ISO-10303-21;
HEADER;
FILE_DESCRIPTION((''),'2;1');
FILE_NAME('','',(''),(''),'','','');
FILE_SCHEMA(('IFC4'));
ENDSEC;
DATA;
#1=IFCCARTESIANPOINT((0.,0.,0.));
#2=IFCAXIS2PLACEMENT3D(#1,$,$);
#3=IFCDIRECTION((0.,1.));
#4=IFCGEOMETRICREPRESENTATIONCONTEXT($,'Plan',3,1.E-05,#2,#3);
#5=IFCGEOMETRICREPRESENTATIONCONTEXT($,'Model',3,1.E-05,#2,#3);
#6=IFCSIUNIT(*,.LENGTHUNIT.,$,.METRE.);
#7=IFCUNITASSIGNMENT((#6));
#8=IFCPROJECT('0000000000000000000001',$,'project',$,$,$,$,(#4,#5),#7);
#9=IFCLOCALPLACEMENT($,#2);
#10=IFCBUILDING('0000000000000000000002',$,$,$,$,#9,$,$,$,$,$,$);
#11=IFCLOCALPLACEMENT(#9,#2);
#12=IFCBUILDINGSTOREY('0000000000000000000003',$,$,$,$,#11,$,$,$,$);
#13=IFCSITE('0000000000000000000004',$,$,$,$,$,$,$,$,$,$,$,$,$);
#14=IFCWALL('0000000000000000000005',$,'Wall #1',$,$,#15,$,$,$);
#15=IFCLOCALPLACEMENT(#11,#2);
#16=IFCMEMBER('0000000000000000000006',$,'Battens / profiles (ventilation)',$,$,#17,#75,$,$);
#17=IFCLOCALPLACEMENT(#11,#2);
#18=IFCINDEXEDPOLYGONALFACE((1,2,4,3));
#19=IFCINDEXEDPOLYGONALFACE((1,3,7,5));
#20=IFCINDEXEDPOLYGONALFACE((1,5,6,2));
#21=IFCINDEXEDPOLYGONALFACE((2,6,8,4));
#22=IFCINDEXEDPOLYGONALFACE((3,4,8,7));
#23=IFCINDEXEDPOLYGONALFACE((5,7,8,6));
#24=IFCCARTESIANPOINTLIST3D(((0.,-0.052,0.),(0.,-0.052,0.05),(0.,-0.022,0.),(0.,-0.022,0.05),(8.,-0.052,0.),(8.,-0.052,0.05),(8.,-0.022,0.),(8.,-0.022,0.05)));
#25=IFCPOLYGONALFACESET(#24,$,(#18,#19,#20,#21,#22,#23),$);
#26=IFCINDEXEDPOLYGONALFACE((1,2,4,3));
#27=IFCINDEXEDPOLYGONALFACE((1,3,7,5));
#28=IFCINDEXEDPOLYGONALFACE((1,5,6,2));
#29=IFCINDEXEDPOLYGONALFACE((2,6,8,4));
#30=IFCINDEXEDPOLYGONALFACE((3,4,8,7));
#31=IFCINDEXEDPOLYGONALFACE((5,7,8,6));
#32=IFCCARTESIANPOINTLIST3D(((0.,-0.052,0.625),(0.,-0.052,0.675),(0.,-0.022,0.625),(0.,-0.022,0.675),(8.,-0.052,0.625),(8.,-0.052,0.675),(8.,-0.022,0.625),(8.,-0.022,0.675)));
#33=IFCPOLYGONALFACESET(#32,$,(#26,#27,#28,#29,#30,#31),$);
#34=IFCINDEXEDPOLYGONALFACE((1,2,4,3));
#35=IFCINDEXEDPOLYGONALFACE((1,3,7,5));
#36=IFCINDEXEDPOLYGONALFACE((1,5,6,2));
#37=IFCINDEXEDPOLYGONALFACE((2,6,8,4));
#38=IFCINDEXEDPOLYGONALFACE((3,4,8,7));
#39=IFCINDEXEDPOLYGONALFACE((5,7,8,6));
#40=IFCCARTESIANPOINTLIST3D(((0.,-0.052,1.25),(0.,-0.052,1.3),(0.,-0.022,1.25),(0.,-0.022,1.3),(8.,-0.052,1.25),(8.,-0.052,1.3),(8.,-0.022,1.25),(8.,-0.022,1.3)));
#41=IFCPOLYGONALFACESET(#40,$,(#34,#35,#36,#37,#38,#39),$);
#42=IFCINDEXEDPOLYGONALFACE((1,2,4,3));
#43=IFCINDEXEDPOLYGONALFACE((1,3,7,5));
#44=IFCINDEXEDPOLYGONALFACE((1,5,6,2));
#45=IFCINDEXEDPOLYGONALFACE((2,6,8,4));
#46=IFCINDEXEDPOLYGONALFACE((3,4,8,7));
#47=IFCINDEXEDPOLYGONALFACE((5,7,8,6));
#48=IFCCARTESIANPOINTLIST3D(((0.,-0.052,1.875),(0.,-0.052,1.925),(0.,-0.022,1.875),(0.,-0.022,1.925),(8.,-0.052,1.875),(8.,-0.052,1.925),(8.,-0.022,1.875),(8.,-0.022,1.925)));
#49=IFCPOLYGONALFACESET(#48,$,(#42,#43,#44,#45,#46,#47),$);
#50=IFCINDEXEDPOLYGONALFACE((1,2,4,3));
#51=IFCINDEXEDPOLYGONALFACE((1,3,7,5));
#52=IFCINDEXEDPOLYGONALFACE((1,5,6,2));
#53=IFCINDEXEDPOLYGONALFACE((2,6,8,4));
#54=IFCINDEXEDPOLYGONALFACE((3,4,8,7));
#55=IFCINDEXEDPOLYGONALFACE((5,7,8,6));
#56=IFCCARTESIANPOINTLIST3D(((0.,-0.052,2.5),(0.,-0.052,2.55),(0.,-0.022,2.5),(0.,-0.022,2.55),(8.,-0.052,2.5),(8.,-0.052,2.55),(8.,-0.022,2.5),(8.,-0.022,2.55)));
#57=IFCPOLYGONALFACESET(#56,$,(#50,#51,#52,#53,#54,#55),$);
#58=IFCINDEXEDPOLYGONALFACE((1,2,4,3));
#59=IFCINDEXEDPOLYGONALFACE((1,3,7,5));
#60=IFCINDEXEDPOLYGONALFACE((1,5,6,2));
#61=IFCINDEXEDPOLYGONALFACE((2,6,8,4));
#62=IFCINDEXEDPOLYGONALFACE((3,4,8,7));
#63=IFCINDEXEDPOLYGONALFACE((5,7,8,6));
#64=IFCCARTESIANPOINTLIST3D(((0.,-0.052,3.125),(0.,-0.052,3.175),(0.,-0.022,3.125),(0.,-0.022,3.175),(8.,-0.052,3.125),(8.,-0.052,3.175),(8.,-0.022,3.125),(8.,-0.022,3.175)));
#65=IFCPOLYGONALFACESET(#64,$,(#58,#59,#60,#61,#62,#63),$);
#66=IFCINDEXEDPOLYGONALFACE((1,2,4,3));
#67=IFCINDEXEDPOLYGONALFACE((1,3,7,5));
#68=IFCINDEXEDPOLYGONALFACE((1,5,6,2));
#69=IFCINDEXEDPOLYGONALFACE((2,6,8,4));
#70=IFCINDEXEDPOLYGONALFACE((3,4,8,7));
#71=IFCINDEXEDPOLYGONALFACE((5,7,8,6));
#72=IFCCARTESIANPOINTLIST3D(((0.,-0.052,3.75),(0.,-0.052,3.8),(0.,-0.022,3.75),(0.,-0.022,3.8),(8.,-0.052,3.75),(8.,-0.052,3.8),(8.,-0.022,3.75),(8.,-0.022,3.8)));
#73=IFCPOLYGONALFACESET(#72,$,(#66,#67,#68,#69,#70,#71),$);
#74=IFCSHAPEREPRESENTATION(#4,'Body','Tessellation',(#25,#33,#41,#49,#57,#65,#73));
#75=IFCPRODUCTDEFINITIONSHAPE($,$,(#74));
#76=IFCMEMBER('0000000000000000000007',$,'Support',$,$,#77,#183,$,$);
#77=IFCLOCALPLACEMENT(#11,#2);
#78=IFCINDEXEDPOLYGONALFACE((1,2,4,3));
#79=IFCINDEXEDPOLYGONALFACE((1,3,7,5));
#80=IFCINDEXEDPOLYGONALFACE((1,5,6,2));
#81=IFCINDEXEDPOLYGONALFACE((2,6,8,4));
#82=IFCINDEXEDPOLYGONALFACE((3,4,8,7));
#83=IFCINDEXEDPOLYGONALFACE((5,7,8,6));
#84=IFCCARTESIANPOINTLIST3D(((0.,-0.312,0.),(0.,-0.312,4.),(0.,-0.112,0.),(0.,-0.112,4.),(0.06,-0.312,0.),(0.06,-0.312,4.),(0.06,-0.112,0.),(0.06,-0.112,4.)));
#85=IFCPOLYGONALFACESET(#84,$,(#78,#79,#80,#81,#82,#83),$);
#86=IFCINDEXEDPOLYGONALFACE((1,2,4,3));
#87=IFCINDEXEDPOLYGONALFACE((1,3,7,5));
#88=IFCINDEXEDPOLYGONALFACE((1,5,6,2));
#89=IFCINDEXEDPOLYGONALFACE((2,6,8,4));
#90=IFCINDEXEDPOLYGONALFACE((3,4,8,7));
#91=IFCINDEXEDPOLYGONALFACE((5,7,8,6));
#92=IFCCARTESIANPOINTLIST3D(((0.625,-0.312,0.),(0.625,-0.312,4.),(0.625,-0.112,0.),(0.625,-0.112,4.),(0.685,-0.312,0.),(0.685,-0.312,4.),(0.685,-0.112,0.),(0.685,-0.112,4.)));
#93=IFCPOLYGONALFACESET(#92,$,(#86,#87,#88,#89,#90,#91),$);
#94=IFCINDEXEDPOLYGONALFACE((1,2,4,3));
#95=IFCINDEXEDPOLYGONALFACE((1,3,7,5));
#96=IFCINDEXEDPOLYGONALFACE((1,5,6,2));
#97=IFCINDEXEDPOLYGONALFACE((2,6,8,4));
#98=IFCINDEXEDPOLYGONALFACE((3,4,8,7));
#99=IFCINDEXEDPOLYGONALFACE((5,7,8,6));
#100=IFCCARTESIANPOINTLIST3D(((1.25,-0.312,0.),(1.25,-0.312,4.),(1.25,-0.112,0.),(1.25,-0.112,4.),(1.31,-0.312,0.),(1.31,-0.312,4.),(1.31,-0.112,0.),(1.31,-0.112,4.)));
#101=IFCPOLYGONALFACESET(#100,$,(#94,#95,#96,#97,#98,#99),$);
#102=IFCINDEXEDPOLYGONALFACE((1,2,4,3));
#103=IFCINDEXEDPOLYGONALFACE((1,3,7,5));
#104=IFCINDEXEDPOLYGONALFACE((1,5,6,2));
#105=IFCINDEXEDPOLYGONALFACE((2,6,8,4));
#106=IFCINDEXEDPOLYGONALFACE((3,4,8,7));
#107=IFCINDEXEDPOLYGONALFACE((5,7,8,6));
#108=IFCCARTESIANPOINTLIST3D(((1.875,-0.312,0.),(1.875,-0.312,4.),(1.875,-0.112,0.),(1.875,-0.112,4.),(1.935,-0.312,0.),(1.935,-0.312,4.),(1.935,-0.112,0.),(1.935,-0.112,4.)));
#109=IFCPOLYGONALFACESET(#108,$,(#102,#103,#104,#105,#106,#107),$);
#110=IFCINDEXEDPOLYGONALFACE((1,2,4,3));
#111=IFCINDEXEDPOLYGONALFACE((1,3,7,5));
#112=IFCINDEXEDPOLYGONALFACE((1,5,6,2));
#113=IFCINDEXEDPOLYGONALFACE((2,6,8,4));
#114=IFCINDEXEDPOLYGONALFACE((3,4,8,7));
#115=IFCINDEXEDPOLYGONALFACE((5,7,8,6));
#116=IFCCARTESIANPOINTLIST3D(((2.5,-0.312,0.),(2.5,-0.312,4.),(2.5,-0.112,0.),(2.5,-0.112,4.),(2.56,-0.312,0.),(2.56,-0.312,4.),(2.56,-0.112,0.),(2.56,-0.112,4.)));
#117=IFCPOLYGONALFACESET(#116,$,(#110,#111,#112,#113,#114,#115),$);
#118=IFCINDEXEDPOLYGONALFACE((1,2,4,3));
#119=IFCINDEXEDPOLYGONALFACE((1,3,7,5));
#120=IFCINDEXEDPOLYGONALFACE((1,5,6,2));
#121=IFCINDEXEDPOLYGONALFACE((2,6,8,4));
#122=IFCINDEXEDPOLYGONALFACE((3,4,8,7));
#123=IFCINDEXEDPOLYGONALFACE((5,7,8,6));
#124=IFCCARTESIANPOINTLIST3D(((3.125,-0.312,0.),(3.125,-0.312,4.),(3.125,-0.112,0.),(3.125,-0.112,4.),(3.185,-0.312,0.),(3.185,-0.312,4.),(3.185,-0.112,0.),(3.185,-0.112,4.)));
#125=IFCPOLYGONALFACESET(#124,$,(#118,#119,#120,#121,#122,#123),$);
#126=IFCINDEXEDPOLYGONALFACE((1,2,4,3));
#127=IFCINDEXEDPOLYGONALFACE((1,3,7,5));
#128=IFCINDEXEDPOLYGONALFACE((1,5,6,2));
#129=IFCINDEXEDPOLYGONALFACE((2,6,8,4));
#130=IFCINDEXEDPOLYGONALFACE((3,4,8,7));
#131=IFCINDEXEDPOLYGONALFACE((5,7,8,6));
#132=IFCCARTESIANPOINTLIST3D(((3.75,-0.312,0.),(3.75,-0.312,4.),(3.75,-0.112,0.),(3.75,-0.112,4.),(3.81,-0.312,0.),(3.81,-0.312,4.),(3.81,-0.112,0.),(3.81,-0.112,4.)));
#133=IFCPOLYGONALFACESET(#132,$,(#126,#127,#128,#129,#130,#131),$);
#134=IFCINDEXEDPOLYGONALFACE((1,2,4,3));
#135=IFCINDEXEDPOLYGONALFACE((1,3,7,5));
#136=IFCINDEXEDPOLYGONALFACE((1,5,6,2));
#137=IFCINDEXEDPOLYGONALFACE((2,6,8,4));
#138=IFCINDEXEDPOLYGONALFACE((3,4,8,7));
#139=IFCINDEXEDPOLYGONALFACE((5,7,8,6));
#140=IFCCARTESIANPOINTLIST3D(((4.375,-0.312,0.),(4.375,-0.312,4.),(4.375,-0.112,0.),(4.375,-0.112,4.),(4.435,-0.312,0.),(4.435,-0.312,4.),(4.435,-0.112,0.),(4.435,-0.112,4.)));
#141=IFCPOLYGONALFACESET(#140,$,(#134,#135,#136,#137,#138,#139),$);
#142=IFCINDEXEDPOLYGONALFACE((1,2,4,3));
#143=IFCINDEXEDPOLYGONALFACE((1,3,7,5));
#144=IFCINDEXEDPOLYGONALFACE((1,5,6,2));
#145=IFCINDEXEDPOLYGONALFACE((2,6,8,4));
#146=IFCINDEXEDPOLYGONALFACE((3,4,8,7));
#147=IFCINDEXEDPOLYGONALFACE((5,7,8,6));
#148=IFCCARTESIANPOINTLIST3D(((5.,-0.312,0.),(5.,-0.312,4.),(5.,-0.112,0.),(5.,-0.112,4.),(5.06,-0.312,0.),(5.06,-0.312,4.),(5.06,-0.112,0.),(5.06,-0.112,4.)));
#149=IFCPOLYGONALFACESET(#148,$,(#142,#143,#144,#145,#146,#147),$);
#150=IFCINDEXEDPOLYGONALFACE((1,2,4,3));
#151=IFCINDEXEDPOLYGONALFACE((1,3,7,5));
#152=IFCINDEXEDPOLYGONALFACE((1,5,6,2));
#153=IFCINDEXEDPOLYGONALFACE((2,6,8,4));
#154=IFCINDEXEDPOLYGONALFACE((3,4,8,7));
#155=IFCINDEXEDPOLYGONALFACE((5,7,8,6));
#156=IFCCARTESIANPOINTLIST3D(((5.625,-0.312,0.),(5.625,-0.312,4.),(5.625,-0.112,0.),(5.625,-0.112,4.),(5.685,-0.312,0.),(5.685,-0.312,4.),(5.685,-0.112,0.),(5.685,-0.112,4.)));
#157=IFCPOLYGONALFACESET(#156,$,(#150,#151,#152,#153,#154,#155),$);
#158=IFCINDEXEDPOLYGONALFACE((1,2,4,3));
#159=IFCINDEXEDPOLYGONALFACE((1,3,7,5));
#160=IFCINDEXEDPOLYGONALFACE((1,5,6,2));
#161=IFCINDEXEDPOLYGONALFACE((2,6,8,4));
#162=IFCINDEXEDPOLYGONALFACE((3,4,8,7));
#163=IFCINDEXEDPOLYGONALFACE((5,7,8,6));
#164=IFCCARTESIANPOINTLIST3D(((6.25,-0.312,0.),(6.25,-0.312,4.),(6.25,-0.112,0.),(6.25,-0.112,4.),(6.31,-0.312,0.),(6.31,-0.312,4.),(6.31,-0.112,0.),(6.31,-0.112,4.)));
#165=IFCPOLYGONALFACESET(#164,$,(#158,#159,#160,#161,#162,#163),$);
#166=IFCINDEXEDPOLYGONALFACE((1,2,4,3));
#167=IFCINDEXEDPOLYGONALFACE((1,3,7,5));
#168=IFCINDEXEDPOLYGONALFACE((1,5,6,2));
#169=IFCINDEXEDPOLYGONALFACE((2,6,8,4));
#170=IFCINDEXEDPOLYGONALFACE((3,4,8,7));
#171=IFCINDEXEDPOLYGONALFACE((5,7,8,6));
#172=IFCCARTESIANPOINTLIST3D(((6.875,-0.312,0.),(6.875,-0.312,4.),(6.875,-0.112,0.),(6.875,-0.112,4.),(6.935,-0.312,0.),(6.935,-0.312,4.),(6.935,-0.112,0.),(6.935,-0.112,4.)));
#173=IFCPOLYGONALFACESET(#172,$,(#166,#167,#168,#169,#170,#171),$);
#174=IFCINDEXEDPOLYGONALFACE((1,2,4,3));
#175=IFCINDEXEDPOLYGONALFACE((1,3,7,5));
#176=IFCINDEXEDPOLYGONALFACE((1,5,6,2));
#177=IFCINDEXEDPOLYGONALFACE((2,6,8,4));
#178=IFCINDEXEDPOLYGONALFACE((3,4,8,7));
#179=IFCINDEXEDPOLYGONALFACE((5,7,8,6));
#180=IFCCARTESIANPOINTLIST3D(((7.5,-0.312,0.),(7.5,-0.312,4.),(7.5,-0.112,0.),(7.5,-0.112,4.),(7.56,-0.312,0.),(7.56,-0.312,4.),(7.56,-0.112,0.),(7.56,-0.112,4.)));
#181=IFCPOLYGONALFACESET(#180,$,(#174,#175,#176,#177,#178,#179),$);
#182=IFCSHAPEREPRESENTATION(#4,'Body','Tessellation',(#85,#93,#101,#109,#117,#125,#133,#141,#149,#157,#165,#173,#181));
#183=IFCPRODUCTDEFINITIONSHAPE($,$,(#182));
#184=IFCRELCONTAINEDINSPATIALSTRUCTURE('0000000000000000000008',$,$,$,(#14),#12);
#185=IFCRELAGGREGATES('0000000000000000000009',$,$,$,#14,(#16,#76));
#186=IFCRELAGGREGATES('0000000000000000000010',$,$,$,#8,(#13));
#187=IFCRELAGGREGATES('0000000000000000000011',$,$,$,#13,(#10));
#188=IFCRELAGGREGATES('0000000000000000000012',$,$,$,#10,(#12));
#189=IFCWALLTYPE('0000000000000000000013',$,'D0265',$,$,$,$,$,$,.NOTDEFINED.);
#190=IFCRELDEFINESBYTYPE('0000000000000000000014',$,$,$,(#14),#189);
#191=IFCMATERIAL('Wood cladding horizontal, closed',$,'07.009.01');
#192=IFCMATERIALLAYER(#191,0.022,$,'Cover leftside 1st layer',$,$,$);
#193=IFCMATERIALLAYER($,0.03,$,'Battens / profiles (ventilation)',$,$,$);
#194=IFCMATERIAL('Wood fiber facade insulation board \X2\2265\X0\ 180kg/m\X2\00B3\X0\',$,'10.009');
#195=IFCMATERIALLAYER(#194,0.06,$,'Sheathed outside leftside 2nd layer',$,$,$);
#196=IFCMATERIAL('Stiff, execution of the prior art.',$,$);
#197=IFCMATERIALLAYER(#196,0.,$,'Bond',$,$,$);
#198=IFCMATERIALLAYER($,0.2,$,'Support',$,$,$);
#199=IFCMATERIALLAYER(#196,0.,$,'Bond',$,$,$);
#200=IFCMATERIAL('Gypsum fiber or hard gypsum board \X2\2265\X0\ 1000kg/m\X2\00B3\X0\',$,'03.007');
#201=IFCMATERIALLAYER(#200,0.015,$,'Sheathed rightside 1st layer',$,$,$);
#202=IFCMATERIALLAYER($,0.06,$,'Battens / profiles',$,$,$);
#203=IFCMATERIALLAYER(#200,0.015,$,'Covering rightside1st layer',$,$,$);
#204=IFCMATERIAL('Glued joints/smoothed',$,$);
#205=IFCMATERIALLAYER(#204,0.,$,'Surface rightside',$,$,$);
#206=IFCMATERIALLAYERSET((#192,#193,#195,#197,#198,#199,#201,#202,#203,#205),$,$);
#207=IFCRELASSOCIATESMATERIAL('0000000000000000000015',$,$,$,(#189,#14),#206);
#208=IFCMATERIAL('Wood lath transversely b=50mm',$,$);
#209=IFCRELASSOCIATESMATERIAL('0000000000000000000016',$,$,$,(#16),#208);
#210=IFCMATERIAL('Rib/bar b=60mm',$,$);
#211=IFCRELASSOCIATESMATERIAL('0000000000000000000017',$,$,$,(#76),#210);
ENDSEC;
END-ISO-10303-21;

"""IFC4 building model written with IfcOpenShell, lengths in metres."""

from ifc_helpers import new_model, si_unit, direction, frame, frame_2d, origin, place, context, project, spatial, rectangle, extrude, material, layer, layer_set, type_object, element, aggregate, save


model = new_model("IFC4")

# Units and contexts
plan_context = context("Plan", 3, precision=1e-05, world=origin(), true_north=direction((0.0, 1.0)))
model_context = context("Model", 3, precision=1e-05, world=origin(), true_north=direction((0.0, 1.0)))
ifc_project = project(units=[si_unit("LENGTHUNIT", "METRE")], contexts=[plan_context, model_context])

# Site, building, storey
site = spatial("IfcSite", under=ifc_project)
building_placement = place(None, origin())
building = spatial("IfcBuilding", under=site, at=building_placement)
storey_placement = place(building_placement, origin())
storey = spatial("IfcBuildingStorey", under=building, at=storey_placement)

# Wall, members
ifc_material_1 = material(Name="Wood cladding horizontal, closed", Category="07.009.01")
ifc_layer_1 = layer(ifc_material_1, 0.022, Name="Cover leftside 1st layer")
ifc_layer_2 = layer(None, 0.03, Name="Battens / profiles (ventilation)")
ifc_material_2 = material(Name="Wood fiber facade insulation board ≥ 180kg/m³", Category="10.009")
ifc_layer_3 = layer(ifc_material_2, 0.06, Name="Sheathed outside leftside 2nd layer")
ifc_material_3 = material(Name="Stiff, execution of the prior art.")
ifc_layer_4 = layer(ifc_material_3, 0.0, Name="Bond")
ifc_layer_5 = layer(None, 0.2, Name="Support")
ifc_layer_6 = layer(ifc_material_3, 0.0, Name="Bond")
ifc_material_4 = material(Name="Gypsum fiber or hard gypsum board ≥ 1000kg/m³", Category="03.007")
ifc_layer_7 = layer(ifc_material_4, 0.015, Name="Sheathed rightside 1st layer")
ifc_layer_8 = layer(None, 0.06, Name="Battens / profiles")
ifc_layer_9 = layer(ifc_material_4, 0.015, Name="Covering rightside1st layer")
ifc_material_5 = material(Name="Glued joints/smoothed")
ifc_layer_10 = layer(ifc_material_5, 0.0, Name="Surface rightside")
ifc_layer_set = layer_set([ifc_layer_1, ifc_layer_2, ifc_layer_3, ifc_layer_4, ifc_layer_5, ifc_layer_6, ifc_layer_7, ifc_layer_8, ifc_layer_9, ifc_layer_10])
wall_type = type_object("IfcWallType", Name="D0265", PredefinedType="NOTDEFINED", material=ifc_layer_set)
wall_placement = place(None, frame((0.0, 0.0, 0.0), z_axis=(0.0, -1.0, 0.0), x_axis=(1.0, 0.0, 0.0)))
wall = element("IfcWall", 1, at=wall_placement, inside=storey, type_object=wall_type, material=ifc_layer_set, Name="Wall #1")
ifc_material_6 = material(Name="Wood lath transversely b=50mm")
member_1_placement = place(wall_placement, origin())
member_1 = element("IfcMember", 2, at=member_1_placement, material=ifc_material_6, Name="Battens / profiles (ventilation)", context=plan_context, shape_type="SweptSolid", body=[
    extrude(rectangle(XDim=0.05, YDim=0.03, at=frame_2d((0.025, 0.015), x_axis=(1.0, 0.0))), frame((0.0, 0.0, 0.022), z_axis=(1.0, 0.0, 0.0), x_axis=(0.0, 1.0, 0.0)), (0.0, 0.0, 1.0), 8.0),
    extrude(rectangle(XDim=0.05, YDim=0.03, at=frame_2d((0.025, 0.015), x_axis=(1.0, 0.0))), frame((0.0, 0.625, 0.022), z_axis=(1.0, 0.0, 0.0), x_axis=(0.0, 1.0, 0.0)), (0.0, 0.0, 1.0), 8.0),
    extrude(rectangle(XDim=0.05, YDim=0.03, at=frame_2d((0.025, 0.015), x_axis=(1.0, 0.0))), frame((0.0, 1.25, 0.022), z_axis=(1.0, 0.0, 0.0), x_axis=(0.0, 1.0, 0.0)), (0.0, 0.0, 1.0), 8.0),
    extrude(rectangle(XDim=0.05, YDim=0.03, at=frame_2d((0.025, 0.015), x_axis=(1.0, 0.0))), frame((0.0, 1.875, 0.022), z_axis=(1.0, 0.0, 0.0), x_axis=(0.0, 1.0, 0.0)), (0.0, 0.0, 1.0), 8.0),
    extrude(rectangle(XDim=0.05, YDim=0.03, at=frame_2d((0.025, 0.015), x_axis=(1.0, 0.0))), frame((0.0, 2.5, 0.022), z_axis=(1.0, 0.0, 0.0), x_axis=(0.0, 1.0, 0.0)), (0.0, 0.0, 1.0), 8.0),
    extrude(rectangle(XDim=0.05, YDim=0.03, at=frame_2d((0.025, 0.015), x_axis=(1.0, 0.0))), frame((0.0, 3.125, 0.022), z_axis=(1.0, 0.0, 0.0), x_axis=(0.0, 1.0, 0.0)), (0.0, 0.0, 1.0), 8.0),
    extrude(rectangle(XDim=0.05, YDim=0.03, at=frame_2d((0.025, 0.015), x_axis=(1.0, 0.0))), frame((0.0, 3.75, 0.022), z_axis=(1.0, 0.0, 0.0), x_axis=(0.0, 1.0, 0.0)), (0.0, 0.0, 1.0), 8.0),
])
ifc_material_7 = material(Name="Rib/bar b=60mm")
member_2_placement = place(wall_placement, origin())
member_2 = element("IfcMember", 3, at=member_2_placement, material=ifc_material_7, Name="Support", context=plan_context, shape_type="SweptSolid", body=[
    extrude(rectangle(XDim=0.06, YDim=0.2, at=frame_2d((0.03, 0.1), x_axis=(1.0, 0.0))), frame((0.0, 4.0, 0.112), z_axis=(0.0, -1.0, 0.0), x_axis=(1.0, 0.0, 0.0)), (0.0, 0.0, 1.0), 4.0),
    extrude(rectangle(XDim=0.06, YDim=0.2, at=frame_2d((0.03, 0.1), x_axis=(1.0, 0.0))), frame((0.625, 4.0, 0.112), z_axis=(0.0, -1.0, 0.0), x_axis=(1.0, 0.0, 0.0)), (0.0, 0.0, 1.0), 4.0),
    extrude(rectangle(XDim=0.06, YDim=0.2, at=frame_2d((0.03, 0.1), x_axis=(1.0, 0.0))), frame((1.25, 4.0, 0.112), z_axis=(0.0, -1.0, 0.0), x_axis=(1.0, 0.0, 0.0)), (0.0, 0.0, 1.0), 4.0),
    extrude(rectangle(XDim=0.06, YDim=0.2, at=frame_2d((0.03, 0.1), x_axis=(1.0, 0.0))), frame((1.875, 4.0, 0.112), z_axis=(0.0, -1.0, 0.0), x_axis=(1.0, 0.0, 0.0)), (0.0, 0.0, 1.0), 4.0),
    extrude(rectangle(XDim=0.06, YDim=0.2, at=frame_2d((0.03, 0.1), x_axis=(1.0, 0.0))), frame((2.5, 4.0, 0.112), z_axis=(0.0, -1.0, 0.0), x_axis=(1.0, 0.0, 0.0)), (0.0, 0.0, 1.0), 4.0),
    extrude(rectangle(XDim=0.06, YDim=0.2, at=frame_2d((0.03, 0.1), x_axis=(1.0, 0.0))), frame((3.125, 4.0, 0.112), z_axis=(0.0, -1.0, 0.0), x_axis=(1.0, 0.0, 0.0)), (0.0, 0.0, 1.0), 4.0),
    extrude(rectangle(XDim=0.06, YDim=0.2, at=frame_2d((0.03, 0.1), x_axis=(1.0, 0.0))), frame((3.75, 4.0, 0.112), z_axis=(0.0, -1.0, 0.0), x_axis=(1.0, 0.0, 0.0)), (0.0, 0.0, 1.0), 4.0),
    extrude(rectangle(XDim=0.06, YDim=0.2, at=frame_2d((0.03, 0.1), x_axis=(1.0, 0.0))), frame((4.375, 4.0, 0.112), z_axis=(0.0, -1.0, 0.0), x_axis=(1.0, 0.0, 0.0)), (0.0, 0.0, 1.0), 4.0),
    extrude(rectangle(XDim=0.06, YDim=0.2, at=frame_2d((0.03, 0.1), x_axis=(1.0, 0.0))), frame((5.0, 4.0, 0.112), z_axis=(0.0, -1.0, 0.0), x_axis=(1.0, 0.0, 0.0)), (0.0, 0.0, 1.0), 4.0),
    extrude(rectangle(XDim=0.06, YDim=0.2, at=frame_2d((0.03, 0.1), x_axis=(1.0, 0.0))), frame((5.625, 4.0, 0.112), z_axis=(0.0, -1.0, 0.0), x_axis=(1.0, 0.0, 0.0)), (0.0, 0.0, 1.0), 4.0),
    extrude(rectangle(XDim=0.06, YDim=0.2, at=frame_2d((0.03, 0.1), x_axis=(1.0, 0.0))), frame((6.25, 4.0, 0.112), z_axis=(0.0, -1.0, 0.0), x_axis=(1.0, 0.0, 0.0)), (0.0, 0.0, 1.0), 4.0),
    extrude(rectangle(XDim=0.06, YDim=0.2, at=frame_2d((0.03, 0.1), x_axis=(1.0, 0.0))), frame((6.875, 4.0, 0.112), z_axis=(0.0, -1.0, 0.0), x_axis=(1.0, 0.0, 0.0)), (0.0, 0.0, 1.0), 4.0),
    extrude(rectangle(XDim=0.06, YDim=0.2, at=frame_2d((0.03, 0.1), x_axis=(1.0, 0.0))), frame((7.5, 4.0, 0.112), z_axis=(0.0, -1.0, 0.0), x_axis=(1.0, 0.0, 0.0)), (0.0, 0.0, 1.0), 4.0),
])
aggregate(wall, [member_1, member_2])

save(model, "model.ifc")
